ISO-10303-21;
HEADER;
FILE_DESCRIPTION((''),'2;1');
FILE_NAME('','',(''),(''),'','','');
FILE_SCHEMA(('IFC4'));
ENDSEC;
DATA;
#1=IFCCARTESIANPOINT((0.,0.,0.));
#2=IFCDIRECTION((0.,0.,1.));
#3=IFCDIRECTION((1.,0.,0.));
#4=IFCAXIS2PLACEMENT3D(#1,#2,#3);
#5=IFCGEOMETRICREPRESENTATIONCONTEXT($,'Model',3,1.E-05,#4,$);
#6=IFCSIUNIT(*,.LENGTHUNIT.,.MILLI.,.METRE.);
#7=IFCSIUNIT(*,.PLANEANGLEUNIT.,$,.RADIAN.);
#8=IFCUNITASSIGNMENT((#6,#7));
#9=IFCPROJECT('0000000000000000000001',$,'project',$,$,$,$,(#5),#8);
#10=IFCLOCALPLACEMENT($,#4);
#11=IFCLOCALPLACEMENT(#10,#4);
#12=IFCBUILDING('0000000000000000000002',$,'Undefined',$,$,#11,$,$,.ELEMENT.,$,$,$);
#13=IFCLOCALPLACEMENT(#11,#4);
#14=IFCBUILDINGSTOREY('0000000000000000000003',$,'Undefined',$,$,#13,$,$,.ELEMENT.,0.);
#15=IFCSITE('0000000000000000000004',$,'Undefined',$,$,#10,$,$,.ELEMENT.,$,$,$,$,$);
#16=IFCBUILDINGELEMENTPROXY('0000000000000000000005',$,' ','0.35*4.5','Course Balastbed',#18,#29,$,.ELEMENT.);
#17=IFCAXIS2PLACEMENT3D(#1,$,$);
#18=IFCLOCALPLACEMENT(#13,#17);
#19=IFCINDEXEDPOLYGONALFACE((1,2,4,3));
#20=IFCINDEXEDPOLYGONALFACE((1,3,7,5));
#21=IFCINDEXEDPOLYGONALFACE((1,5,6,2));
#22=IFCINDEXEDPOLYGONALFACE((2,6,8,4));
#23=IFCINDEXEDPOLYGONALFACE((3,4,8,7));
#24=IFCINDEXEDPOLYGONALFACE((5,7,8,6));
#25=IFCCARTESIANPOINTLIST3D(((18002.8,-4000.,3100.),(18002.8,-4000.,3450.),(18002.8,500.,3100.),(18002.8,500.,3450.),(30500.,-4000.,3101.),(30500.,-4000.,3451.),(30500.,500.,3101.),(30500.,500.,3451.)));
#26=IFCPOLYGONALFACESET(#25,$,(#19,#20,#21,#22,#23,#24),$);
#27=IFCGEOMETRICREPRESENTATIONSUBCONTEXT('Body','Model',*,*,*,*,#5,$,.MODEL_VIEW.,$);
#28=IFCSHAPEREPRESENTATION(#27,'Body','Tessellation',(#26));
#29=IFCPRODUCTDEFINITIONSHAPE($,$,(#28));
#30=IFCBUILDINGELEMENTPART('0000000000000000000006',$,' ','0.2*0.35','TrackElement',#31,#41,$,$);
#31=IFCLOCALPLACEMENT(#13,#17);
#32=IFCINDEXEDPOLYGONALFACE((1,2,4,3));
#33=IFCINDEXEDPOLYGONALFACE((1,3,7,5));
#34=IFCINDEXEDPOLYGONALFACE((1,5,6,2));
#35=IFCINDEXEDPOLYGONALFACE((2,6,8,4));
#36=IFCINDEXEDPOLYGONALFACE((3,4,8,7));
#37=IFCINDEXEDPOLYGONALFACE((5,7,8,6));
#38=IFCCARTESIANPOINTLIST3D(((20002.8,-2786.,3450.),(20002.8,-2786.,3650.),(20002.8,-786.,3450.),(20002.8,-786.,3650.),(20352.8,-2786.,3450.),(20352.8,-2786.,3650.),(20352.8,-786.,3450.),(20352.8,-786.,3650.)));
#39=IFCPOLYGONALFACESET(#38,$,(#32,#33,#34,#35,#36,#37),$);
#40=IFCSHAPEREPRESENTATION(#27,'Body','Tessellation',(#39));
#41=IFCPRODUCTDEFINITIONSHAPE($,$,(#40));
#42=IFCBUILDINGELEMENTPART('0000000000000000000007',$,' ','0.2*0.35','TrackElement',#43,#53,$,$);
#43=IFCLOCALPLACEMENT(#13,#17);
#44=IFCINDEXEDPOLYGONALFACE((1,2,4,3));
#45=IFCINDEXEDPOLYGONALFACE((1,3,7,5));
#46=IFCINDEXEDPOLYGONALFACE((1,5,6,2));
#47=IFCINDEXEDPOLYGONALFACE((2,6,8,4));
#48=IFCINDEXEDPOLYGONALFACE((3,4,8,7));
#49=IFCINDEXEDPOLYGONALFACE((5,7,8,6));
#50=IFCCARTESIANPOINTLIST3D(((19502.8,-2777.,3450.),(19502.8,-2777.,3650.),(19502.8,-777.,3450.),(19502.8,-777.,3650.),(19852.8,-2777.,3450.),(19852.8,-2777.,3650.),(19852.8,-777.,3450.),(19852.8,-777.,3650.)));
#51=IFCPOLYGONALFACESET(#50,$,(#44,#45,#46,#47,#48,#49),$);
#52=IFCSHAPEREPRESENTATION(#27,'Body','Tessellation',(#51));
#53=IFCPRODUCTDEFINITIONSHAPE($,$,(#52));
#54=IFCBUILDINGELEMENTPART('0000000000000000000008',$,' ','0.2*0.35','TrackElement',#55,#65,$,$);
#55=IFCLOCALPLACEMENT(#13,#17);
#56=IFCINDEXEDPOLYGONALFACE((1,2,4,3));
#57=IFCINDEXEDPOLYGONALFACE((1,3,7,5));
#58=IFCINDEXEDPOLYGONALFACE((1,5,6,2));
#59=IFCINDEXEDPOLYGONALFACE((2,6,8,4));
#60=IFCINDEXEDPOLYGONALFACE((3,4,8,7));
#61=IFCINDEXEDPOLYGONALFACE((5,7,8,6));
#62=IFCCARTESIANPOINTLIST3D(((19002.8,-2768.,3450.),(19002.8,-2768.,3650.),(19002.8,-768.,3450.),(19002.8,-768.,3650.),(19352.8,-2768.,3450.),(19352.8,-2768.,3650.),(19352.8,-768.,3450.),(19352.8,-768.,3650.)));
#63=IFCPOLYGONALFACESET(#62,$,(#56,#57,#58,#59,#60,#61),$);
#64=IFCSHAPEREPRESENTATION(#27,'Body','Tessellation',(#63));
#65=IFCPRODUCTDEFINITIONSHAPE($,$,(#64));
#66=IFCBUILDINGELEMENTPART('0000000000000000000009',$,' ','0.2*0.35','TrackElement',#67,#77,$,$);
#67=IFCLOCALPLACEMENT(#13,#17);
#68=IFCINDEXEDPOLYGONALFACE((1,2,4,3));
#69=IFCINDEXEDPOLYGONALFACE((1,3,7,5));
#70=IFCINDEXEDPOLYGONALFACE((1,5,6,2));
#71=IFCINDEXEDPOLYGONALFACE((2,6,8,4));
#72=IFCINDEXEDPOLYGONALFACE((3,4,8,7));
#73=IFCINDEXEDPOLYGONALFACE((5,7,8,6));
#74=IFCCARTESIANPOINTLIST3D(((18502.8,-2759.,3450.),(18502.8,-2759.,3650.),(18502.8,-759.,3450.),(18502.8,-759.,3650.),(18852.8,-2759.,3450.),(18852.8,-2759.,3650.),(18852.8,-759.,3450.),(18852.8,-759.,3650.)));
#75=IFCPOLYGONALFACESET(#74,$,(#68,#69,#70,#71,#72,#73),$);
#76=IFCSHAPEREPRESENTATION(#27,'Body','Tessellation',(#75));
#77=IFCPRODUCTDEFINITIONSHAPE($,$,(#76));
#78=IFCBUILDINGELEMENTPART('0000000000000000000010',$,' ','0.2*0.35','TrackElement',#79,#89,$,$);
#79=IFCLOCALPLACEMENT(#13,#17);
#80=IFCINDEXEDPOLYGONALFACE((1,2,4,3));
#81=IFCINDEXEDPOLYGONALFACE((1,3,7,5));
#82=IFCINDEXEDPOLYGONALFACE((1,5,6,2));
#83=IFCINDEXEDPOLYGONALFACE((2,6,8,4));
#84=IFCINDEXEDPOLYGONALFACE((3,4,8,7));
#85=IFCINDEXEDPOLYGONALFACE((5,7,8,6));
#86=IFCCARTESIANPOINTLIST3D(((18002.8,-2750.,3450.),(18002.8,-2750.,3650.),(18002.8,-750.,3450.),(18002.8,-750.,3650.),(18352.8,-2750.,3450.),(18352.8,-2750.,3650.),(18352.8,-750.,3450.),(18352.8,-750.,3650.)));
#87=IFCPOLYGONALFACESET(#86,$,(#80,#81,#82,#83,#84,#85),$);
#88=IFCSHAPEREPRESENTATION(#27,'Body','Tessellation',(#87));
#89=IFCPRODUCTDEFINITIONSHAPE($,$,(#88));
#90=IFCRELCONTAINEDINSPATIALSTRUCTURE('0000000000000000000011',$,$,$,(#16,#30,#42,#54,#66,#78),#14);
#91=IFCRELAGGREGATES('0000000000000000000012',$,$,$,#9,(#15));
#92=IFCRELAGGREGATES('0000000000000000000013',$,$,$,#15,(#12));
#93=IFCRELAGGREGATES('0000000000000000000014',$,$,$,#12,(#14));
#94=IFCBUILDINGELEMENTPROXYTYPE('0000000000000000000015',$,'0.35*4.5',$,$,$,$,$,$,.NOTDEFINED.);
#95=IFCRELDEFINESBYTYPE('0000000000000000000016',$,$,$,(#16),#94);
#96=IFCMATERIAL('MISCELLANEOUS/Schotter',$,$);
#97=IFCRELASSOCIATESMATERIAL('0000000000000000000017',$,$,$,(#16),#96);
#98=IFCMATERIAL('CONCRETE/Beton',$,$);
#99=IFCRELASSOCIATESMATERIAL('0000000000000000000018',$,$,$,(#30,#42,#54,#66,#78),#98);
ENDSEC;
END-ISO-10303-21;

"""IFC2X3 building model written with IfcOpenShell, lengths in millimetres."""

from ifc_helpers import new_model, si_unit, frame, origin_with_axes, origin_2d_with_axis, place, context, subcontext, project, spatial, polyline, rectangle, outline, extrude, material, type_object, element, save


model = new_model("IFC2X3")

# Units and contexts
model_context = context("Model", 3, precision=1e-05, world=origin_with_axes())
body_context = subcontext(model_context, "Body", "Model", "MODEL_VIEW")
ifc_project = project(units=[si_unit("LENGTHUNIT", "METRE", prefix="MILLI"), si_unit("PLANEANGLEUNIT", "RADIAN")], contexts=[model_context])

# Site, building, storey
site_placement = place(None, origin_with_axes())
site = spatial("IfcSite", under=ifc_project, at=site_placement, Name="Undefined", CompositionType="ELEMENT")
building_placement = place(site_placement, origin_with_axes())
building = spatial("IfcBuilding", under=site, at=building_placement, Name="Undefined", CompositionType="ELEMENT")
storey_placement = place(building_placement, origin_with_axes())
storey = spatial("IfcBuildingStorey", under=building, at=storey_placement, Name="Undefined", CompositionType="ELEMENT", Elevation=0.0)

# Building element proxy
ifc_material_1 = material(Name="MISCELLANEOUS/Schotter")
building_element_proxy_type = type_object("IfcBuildingElementProxyType", Name="0.35*4.5", PredefinedType="NOTDEFINED")
proxy_placement = place(storey_placement, frame((18002.8, 500.0, 3275.0), z_axis=(-0.00008, 0.0, 1.0), x_axis=(0.0, -1.0, 0.0)))
element("IfcBuildingElementProxy", 1, at=proxy_placement, inside=storey, type_object=building_element_proxy_type, material=ifc_material_1, Name=" ", Description="0.35*4.5", ObjectType="Course Balastbed", CompositionType="ELEMENT", context=body_context, shape_type="SweptSolid", body=[
    extrude(outline(polyline([(0.0, 0.0), (4500.0, 0.0), (4500.0, -2.8), (4500.0, 12497.2), (0.0, 12497.2), (0.0, 0.0)])), frame((0.0, 0.0, -175.0), z_axis=(0.0, 0.0, 1.0), x_axis=(1.0, 0.0, 0.0)), (0.0, 0.0, 1.0), 350.0),
])

# Building element parts
ifc_material_2 = material(Name="CONCRETE/Beton")
for number, where, z_axis, x_axis, name in (
    (2, (20177.8, -786.0, 3550.0), (0.0, 0.0, 1.0), (0.0, -1.0, 0.0), " "),
    (3, (19677.8, -777.0, 3550.0), (0.0, 0.0, 1.0), (0.0, -1.0, 0.0), " "),
    (4, (19177.8, -768.0, 3550.0), (0.0, 0.0, 1.0), (0.0, -1.0, 0.0), " "),
    (5, (18677.8, -759.0, 3550.0), (0.0, 0.0, 1.0), (0.0, -1.0, 0.0), " "),
    (6, (18177.8, -750.0, 3550.0), (0.0, 0.0, 1.0), (0.0, -1.0, 0.0), " "),
):
    element("IfcBuildingElementPart", number, at=place(storey_placement, frame(where, z_axis=z_axis, x_axis=x_axis)), inside=storey, material=ifc_material_2, Name=name, Description="0.2*0.35", ObjectType="TrackElement", context=body_context, shape_type="SweptSolid", body=[
        extrude(rectangle(XDim=350.0, YDim=200.0, at=origin_2d_with_axis()), frame((2000.0, 0.0, 0.0), z_axis=(-1.0, 0.0, 0.0), x_axis=(0.0, -1.0, 0.0)), (0.0, 0.0, 1.0), 2000.0),
    ])

save(model, "model.ifc")
